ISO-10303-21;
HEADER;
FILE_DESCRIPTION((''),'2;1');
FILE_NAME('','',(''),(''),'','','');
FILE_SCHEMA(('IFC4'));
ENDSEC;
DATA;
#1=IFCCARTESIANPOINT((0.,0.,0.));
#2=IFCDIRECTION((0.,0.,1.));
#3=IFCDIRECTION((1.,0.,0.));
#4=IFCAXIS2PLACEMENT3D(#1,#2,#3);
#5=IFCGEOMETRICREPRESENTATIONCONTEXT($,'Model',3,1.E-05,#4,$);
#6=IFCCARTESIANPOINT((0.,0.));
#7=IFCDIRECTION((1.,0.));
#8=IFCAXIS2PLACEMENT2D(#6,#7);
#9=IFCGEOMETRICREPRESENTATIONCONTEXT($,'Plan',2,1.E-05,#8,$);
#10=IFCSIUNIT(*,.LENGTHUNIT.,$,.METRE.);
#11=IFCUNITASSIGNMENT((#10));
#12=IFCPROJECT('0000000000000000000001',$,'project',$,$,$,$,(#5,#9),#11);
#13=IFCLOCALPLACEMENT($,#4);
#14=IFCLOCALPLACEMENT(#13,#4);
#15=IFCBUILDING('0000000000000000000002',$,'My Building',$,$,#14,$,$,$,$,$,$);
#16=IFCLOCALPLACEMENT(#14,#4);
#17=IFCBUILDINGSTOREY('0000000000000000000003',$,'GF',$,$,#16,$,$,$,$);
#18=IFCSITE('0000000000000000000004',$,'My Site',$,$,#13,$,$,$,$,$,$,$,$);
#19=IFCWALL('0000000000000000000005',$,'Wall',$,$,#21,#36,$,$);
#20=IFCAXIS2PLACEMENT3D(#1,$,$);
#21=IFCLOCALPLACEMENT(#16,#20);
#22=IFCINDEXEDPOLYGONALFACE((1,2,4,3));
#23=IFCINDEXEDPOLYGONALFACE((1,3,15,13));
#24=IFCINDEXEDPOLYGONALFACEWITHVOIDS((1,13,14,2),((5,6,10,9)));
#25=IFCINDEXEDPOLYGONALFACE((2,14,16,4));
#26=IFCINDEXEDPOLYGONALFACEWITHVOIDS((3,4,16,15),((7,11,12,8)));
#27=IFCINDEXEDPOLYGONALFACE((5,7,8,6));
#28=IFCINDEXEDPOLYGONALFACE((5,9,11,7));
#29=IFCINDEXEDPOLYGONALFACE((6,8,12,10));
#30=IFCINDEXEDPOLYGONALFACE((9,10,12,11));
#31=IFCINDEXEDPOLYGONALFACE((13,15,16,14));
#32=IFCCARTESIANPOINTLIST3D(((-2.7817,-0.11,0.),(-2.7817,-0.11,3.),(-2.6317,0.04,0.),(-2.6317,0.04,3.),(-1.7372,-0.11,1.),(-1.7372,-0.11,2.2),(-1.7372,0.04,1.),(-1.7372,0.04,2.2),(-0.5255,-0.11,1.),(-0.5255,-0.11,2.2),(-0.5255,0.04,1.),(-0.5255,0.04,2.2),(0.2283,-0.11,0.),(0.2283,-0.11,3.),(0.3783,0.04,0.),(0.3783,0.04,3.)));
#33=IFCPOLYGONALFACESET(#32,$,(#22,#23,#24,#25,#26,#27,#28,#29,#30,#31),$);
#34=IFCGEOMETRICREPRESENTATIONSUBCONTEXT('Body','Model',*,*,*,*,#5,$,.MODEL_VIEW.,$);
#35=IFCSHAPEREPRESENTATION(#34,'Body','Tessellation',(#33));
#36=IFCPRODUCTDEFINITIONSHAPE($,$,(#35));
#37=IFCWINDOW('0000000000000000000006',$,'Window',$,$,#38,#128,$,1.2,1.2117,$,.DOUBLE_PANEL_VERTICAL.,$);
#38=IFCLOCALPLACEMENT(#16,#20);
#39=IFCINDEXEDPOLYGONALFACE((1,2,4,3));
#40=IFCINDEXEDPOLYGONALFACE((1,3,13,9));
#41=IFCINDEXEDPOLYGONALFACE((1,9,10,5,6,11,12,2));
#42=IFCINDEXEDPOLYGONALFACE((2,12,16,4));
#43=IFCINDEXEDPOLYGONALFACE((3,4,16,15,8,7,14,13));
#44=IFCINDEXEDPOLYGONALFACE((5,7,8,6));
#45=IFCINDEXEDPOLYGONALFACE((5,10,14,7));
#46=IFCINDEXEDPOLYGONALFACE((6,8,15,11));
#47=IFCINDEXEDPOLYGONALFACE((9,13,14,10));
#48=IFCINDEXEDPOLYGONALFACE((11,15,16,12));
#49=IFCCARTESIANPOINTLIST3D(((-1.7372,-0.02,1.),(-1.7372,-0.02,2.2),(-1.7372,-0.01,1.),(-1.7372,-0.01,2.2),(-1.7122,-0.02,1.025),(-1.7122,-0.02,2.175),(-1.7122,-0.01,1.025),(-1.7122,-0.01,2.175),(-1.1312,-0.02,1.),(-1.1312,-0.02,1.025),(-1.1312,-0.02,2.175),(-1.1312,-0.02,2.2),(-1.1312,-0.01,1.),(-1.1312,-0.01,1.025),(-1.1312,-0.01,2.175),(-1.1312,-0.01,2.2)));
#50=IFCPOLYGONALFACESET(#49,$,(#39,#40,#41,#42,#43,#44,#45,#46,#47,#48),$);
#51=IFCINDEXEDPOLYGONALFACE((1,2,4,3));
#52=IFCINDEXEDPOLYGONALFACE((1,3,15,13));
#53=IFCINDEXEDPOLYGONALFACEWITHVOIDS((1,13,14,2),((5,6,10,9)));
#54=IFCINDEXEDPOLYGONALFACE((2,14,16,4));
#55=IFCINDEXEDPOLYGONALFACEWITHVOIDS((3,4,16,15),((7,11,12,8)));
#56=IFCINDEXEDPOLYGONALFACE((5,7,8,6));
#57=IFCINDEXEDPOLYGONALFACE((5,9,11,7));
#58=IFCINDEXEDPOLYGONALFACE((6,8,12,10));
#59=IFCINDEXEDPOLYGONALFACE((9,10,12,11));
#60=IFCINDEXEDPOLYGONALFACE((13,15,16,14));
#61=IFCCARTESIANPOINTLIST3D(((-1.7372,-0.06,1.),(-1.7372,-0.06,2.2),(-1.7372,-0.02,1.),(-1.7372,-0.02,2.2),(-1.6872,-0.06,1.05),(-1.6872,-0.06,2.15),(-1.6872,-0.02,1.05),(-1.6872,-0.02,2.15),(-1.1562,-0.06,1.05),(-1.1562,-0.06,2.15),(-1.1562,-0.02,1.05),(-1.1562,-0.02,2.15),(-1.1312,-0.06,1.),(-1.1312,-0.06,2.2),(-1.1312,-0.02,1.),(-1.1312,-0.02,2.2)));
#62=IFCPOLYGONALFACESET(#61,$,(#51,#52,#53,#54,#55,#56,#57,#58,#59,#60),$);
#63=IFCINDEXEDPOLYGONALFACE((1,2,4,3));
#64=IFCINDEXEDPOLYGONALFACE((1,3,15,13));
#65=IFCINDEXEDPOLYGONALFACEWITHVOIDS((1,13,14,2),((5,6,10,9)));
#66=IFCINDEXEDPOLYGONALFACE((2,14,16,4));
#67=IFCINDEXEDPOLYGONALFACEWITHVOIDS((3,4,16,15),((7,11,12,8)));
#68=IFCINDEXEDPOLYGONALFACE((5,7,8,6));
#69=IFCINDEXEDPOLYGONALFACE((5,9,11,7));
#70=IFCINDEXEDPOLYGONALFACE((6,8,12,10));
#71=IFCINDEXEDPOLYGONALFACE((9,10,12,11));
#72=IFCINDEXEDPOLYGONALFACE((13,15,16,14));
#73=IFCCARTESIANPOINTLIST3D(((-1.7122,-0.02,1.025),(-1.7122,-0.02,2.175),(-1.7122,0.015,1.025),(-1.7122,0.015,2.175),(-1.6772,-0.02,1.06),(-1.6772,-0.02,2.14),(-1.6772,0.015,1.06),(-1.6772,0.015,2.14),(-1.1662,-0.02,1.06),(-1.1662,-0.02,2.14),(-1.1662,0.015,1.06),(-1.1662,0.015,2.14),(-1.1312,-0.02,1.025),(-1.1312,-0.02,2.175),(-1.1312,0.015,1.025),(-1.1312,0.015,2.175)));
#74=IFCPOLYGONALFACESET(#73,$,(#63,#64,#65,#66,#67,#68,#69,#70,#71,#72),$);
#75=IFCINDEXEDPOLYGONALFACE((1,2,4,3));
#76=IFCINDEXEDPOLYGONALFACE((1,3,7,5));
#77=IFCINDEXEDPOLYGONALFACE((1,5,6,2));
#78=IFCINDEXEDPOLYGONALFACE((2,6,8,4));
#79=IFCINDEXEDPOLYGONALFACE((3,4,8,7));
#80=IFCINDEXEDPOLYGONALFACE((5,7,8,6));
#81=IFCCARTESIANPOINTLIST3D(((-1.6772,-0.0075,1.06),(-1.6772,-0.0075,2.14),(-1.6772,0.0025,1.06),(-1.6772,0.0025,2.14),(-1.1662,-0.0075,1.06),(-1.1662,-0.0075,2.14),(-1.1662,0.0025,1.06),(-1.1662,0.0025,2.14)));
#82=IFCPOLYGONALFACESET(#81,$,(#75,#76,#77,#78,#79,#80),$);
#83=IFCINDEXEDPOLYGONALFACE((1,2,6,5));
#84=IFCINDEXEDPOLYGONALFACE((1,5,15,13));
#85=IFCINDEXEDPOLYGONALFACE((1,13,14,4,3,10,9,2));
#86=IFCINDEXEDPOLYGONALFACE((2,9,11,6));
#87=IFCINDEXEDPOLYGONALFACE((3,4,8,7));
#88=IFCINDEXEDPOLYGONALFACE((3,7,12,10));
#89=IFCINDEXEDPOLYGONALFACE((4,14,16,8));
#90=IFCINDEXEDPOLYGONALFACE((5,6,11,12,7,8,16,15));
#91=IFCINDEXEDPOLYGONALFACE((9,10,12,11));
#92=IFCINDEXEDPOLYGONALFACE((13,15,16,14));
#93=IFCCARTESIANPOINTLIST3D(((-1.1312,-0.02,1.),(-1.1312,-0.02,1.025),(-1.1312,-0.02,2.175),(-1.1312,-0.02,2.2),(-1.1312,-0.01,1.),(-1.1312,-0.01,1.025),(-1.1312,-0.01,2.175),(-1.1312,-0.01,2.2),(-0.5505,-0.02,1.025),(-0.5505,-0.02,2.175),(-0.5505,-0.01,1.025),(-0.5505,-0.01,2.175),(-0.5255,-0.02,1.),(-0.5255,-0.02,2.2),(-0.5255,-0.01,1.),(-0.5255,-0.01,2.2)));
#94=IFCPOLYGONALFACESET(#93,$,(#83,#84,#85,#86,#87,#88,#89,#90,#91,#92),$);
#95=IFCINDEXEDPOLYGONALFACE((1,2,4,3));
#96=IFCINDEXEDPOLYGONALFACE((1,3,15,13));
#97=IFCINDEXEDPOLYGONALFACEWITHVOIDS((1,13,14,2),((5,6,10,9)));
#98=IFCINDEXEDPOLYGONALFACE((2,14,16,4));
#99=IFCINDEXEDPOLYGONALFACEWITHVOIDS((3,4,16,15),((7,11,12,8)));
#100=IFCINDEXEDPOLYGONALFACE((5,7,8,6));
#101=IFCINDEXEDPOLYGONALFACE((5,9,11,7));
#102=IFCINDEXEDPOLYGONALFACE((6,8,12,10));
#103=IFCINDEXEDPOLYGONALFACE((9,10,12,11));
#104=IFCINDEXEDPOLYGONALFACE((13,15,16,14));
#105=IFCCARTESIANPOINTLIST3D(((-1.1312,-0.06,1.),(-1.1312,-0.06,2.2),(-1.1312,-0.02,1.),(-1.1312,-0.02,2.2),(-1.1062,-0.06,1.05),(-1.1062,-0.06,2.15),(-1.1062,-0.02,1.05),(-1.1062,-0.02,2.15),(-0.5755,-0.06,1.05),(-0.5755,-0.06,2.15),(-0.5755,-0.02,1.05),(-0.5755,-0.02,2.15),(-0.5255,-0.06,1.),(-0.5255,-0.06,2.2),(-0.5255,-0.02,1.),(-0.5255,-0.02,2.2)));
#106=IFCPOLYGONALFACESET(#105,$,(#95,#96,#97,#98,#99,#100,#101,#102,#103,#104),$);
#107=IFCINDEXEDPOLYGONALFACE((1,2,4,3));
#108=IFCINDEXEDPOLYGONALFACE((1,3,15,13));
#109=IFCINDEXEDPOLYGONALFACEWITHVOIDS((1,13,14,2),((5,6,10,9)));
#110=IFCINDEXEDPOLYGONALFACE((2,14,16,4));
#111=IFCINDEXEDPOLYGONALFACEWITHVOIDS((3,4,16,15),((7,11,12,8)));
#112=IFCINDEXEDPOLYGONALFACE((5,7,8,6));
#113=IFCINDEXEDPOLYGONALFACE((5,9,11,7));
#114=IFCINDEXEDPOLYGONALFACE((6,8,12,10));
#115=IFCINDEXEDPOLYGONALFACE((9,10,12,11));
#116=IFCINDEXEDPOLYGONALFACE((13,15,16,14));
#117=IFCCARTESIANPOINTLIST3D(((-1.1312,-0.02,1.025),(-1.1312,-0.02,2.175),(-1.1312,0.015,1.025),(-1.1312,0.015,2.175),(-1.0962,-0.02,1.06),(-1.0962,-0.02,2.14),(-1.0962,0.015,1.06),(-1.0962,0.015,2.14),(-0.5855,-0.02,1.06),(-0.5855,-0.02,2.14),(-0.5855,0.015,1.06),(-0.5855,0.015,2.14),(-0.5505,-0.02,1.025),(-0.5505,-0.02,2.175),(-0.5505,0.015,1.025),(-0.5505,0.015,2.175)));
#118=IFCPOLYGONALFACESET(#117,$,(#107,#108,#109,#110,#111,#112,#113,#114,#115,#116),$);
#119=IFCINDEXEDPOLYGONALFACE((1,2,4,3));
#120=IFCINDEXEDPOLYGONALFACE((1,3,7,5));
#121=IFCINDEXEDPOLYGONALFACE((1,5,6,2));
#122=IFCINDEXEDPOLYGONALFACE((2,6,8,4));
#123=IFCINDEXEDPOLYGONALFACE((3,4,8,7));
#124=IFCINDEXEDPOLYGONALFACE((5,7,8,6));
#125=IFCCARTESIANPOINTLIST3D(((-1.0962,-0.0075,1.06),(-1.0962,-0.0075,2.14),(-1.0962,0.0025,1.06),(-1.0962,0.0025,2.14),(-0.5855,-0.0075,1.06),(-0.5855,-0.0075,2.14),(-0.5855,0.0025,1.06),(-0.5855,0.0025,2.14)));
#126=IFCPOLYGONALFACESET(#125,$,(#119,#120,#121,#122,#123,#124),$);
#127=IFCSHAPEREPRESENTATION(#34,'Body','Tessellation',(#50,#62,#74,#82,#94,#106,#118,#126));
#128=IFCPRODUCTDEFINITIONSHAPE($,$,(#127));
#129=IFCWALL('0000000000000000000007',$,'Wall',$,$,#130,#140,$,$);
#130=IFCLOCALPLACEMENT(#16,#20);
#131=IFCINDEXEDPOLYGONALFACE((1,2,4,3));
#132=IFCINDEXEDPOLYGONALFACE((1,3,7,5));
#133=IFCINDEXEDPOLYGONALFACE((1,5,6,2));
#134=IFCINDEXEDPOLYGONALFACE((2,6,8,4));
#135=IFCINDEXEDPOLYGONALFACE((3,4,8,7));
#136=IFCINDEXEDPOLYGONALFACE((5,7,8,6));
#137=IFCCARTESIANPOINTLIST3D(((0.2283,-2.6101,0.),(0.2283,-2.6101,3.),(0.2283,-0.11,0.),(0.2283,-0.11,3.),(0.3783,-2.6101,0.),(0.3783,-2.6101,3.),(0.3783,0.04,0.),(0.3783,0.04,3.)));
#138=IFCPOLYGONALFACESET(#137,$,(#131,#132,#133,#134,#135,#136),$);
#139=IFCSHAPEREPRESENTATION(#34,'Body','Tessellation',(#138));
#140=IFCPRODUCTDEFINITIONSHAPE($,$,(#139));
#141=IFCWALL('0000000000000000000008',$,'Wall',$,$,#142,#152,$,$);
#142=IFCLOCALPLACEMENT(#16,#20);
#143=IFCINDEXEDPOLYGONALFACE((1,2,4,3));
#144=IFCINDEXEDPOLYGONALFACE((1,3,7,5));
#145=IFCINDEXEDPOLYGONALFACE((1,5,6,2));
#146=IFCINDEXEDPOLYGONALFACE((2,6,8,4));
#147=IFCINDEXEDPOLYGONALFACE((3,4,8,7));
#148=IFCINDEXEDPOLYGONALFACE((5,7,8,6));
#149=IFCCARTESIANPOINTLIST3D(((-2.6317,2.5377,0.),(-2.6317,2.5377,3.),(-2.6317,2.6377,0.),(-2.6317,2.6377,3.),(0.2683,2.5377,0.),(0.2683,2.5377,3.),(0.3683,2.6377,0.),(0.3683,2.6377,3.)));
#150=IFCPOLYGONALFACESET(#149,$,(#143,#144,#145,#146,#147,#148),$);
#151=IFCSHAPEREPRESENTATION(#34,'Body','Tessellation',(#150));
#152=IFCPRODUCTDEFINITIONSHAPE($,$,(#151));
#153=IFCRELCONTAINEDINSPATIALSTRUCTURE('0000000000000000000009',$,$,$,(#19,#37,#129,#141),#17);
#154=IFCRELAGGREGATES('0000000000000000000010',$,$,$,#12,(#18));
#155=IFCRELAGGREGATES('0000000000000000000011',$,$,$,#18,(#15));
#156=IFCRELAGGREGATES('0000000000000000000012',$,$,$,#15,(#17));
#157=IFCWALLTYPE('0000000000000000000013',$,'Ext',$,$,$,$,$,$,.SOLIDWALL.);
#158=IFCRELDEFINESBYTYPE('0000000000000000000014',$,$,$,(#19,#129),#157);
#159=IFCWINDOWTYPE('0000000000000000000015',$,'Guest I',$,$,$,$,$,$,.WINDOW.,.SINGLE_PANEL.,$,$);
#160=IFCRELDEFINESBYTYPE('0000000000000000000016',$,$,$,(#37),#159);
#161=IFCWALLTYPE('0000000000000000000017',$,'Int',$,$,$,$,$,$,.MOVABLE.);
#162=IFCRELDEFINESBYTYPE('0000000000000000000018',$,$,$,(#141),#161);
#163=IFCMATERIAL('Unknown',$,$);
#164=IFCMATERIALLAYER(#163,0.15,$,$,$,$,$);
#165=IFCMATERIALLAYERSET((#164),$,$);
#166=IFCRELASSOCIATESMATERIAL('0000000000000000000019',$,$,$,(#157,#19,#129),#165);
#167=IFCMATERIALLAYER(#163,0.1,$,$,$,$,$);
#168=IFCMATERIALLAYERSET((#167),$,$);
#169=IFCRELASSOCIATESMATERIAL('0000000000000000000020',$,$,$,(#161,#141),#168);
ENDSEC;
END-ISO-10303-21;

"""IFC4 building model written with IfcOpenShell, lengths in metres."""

from ifc_helpers import new_model, entity, si_unit, frame, origin_with_axes, origin_2d_with_axis, place, context, subcontext, project, spatial, line, indexed_curve, outline, extrude, shape, source, transform, mapped, material, layer, layer_set, layer_usage, type_object, type_shapes, element, fill, save


model = new_model("IFC4")

# Units and contexts
model_context = context("Model", 3, precision=1e-05, world=origin_with_axes())
plan_context = context("Plan", 2, precision=1e-05, world=origin_2d_with_axis())
body_context_1 = subcontext(model_context, "Body", "Model", "MODEL_VIEW")
body_context_2 = subcontext(plan_context, "Body", "Plan", "PLAN_VIEW")
ifc_project = project(units=[si_unit("LENGTHUNIT", "METRE")], contexts=[model_context, plan_context])

# Site, building, storey
site_placement = place(None, origin_with_axes())
site = spatial("IfcSite", under=ifc_project, at=site_placement, Name="My Site")
building_placement = place(site_placement, origin_with_axes())
building = spatial("IfcBuilding", under=site, at=building_placement, Name="My Building")
storey_placement = place(building_placement, origin_with_axes())
storey = spatial("IfcBuildingStorey", under=building, at=storey_placement, Name="GF")

# Shared definitions
ifc_material = material(Name="Unknown")

# Shared definitions
ifc_layer_1 = layer(ifc_material, 0.15)
ifc_layer_set_1 = layer_set([ifc_layer_1])
wall_type_1 = type_object("IfcWallType", Name="Ext", PredefinedType="SOLIDWALL", material=ifc_layer_set_1)

# Wall, opening, window
ifc_layer_usage_1 = layer_usage(ifc_layer_set_1, "AXIS2", "POSITIVE", 0.0)
wall_1_placement = place(storey_placement, frame((-2.7817, -0.11, 0.0), z_axis=(0.0, 0.0, 1.0), x_axis=(1.0, 0.0, 0.0)))
wall_1 = element("IfcWall", 1, at=wall_1_placement, inside=storey, type_object=wall_type_1, material=ifc_layer_usage_1, Name="Wall", context=body_context_1, shape_type="SweptSolid", body=[
    extrude(outline(indexed_curve([(0.0, 0.0), (0.15, 0.15), (3.16, 0.15), (3.01, 0.0)], segments=[line(1, 2, 3, 4, 1)])), origin_with_axes(), (0.0, 0.0, 1.0), 3.0),
])
shared_shape_1 = source(origin_with_axes(), body_context_1, "Body", "SweptSolid", [
    extrude(outline(indexed_curve([(0.0, 0.0), (1.2117, 0.0), (1.2117, 1.2), (0.0, 1.2)], segments=[line(1, 2, 3, 4, 1)])), frame((0.0, -0.6, 0.0), z_axis=(0.0, -1.0, 0.0), x_axis=(1.0, 0.0, 0.0)), (0.0, 0.0, -1.0), 1.2),
])
opening_1_placement = place(wall_1_placement, frame((1.0445, 0.0, 1.0), z_axis=(0.0, 0.0, 1.0), x_axis=(1.0, 0.0, 0.0)))
opening_1 = element("IfcOpeningElement", 2, at=opening_1_placement, cuts=wall_1, PredefinedType="OPENING", context=body_context_1, shape_type="MappedRepresentation", body=[
    mapped(shared_shape_1, transform((0.0, 0.0, 0.0), x_axis=(1.0, 0.0, 0.0), y_axis=(0.0, 1.0, 0.0), z_axis=(0.0, 0.0, 1.0), scale=1.0)),
])
window_type_1 = type_object("IfcWindowType", Name="Guest I", PartitioningType="SINGLE_PANEL", PredefinedType="WINDOW")
shared_shape_2 = source(origin_with_axes(), body_context_1, "Body", "SweptSolid", [
    extrude(outline(indexed_curve([(0.606, 0.0), (0.0, 0.0), (0.0, 1.2), (0.606, 1.2), (0.606, 1.175), (0.025, 1.175), (0.025, 0.025), (0.606, 0.025)], segments=[line(1, 2, 3, 4, 5, 6, 7, 8, 1)])), frame((0.0, 0.09, 0.0), z_axis=(0.0, -1.0, 0.0), x_axis=(1.0, 0.0, 0.0)), (0.0, 0.0, -1.0), 0.01),
    extrude(outline(indexed_curve([(0.0, 0.0), (0.606, 0.0), (0.606, 1.2), (0.0, 1.2)], segments=[line(1, 2, 3, 4, 1)]), holes=[indexed_curve([(0.05, 0.05), (0.581, 0.05), (0.581, 1.15), (0.05, 1.15)], segments=[line(1, 2, 3, 4, 1)])]), frame((0.0, 0.05, 0.0), z_axis=(0.0, -1.0, 0.0), x_axis=(1.0, 0.0, 0.0)), (0.0, 0.0, -1.0), 0.04),
    extrude(outline(indexed_curve([(0.0, 0.0), (0.581, 0.0), (0.581, 1.15), (0.0, 1.15)], segments=[line(1, 2, 3, 4, 1)]), holes=[indexed_curve([(0.035, 0.035), (0.546, 0.035), (0.546, 1.115), (0.035, 1.115)], segments=[line(1, 2, 3, 4, 1)])]), frame((0.025, 0.09, 0.025), z_axis=(0.0, -1.0, 0.0), x_axis=(1.0, 0.0, 0.0)), (0.0, 0.0, -1.0), 0.035),
    extrude(outline(indexed_curve([(0.035, 0.035), (0.546, 0.035), (0.546, 1.115), (0.035, 1.115)], segments=[line(1, 2, 3, 4, 1)])), frame((0.025, 0.1025, 0.025), z_axis=(0.0, -1.0, 0.0), x_axis=(1.0, 0.0, 0.0)), (0.0, 0.0, -1.0), 0.01),
    extrude(outline(indexed_curve([(0.0, 1.2), (0.6057, 1.2), (0.6057, 0.0), (0.0, 0.0), (0.0, 0.025), (0.5807, 0.025), (0.5807, 1.175), (0.0, 1.175)], segments=[line(1, 2, 3, 4, 5, 6, 7, 8, 1)])), frame((0.606, 0.09, 0.0), z_axis=(0.0, -1.0, 0.0), x_axis=(1.0, 0.0, 0.0)), (0.0, 0.0, -1.0), 0.01),
    extrude(outline(indexed_curve([(0.0, 0.0), (0.6057, 0.0), (0.6057, 1.2), (0.0, 1.2)], segments=[line(1, 2, 3, 4, 1)]), holes=[indexed_curve([(0.025, 0.05), (0.5557, 0.05), (0.5557, 1.15), (0.025, 1.15)], segments=[line(1, 2, 3, 4, 1)])]), frame((0.606, 0.05, 0.0), z_axis=(0.0, -1.0, 0.0), x_axis=(1.0, 0.0, 0.0)), (0.0, 0.0, -1.0), 0.04),
    extrude(outline(indexed_curve([(0.0, 0.0), (0.5807, 0.0), (0.5807, 1.15), (0.0, 1.15)], segments=[line(1, 2, 3, 4, 1)]), holes=[indexed_curve([(0.035, 0.035), (0.5457, 0.035), (0.5457, 1.115), (0.035, 1.115)], segments=[line(1, 2, 3, 4, 1)])]), frame((0.606, 0.09, 0.025), z_axis=(0.0, -1.0, 0.0), x_axis=(1.0, 0.0, 0.0)), (0.0, 0.0, -1.0), 0.035),
    extrude(outline(indexed_curve([(0.035, 0.035), (0.5457, 0.035), (0.5457, 1.115), (0.035, 1.115)], segments=[line(1, 2, 3, 4, 1)])), frame((0.606, 0.1025, 0.025), z_axis=(0.0, -1.0, 0.0), x_axis=(1.0, 0.0, 0.0)), (0.0, 0.0, -1.0), 0.01),
])
shared_shape_3 = source(origin_with_axes(), body_context_2, "Body", "Curve2D", [
    entity("IfcIndexedPolyCurve", entity("IfcCartesianPointList2D", [[0.05, 0.05], [0.581, 0.05]])),
    entity("IfcIndexedPolyCurve", entity("IfcCartesianPointList2D", [[0.0, 0.1], [0.025, 0.1], [0.025, 0.09], [0.05, 0.09], [0.05, 0.05], [0.0, 0.05]]), [entity("IfcLineIndex", [1, 2, 3, 4, 5, 6, 1])]),
    entity("IfcIndexedPolyCurve", entity("IfcCartesianPointList2D", [[0.606, 0.1], [0.606, 0.1], [0.606, 0.09], [0.581, 0.09], [0.581, 0.05], [0.606, 0.05]])),
    entity("IfcIndexedPolyCurve", entity("IfcCartesianPointList2D", [[0.025, 0.09], [0.06, 0.09], [0.06, 0.125], [0.025, 0.125]]), [entity("IfcLineIndex", [1, 2, 3, 4, 1])]),
    entity("IfcIndexedPolyCurve", entity("IfcCartesianPointList2D", [[0.606, 0.09], [0.571, 0.09], [0.571, 0.125], [0.606, 0.125]]), [entity("IfcLineIndex", [1, 2, 3, 4, 1])]),
    entity("IfcIndexedPolyCurve", entity("IfcCartesianPointList2D", [[0.06, 0.09], [0.571, 0.09]])),
    entity("IfcIndexedPolyCurve", entity("IfcCartesianPointList2D", [[0.06, 0.125], [0.571, 0.125]])),
    entity("IfcIndexedPolyCurve", entity("IfcCartesianPointList2D", [[0.06, 0.1075], [0.571, 0.1075]])),
    entity("IfcIndexedPolyCurve", entity("IfcCartesianPointList2D", [[0.631, 0.05], [1.1617, 0.05]])),
    entity("IfcIndexedPolyCurve", entity("IfcCartesianPointList2D", [[0.606, 0.1], [0.606, 0.1], [0.606, 0.09], [0.631, 0.09], [0.631, 0.05], [0.606, 0.05]])),
    entity("IfcIndexedPolyCurve", entity("IfcCartesianPointList2D", [[1.2117, 0.1], [1.1867, 0.1], [1.1867, 0.09], [1.1617, 0.09], [1.1617, 0.05], [1.2117, 0.05]]), [entity("IfcLineIndex", [1, 2, 3, 4, 5, 6, 1])]),
    entity("IfcIndexedPolyCurve", entity("IfcCartesianPointList2D", [[0.606, 0.09], [0.641, 0.09], [0.641, 0.125], [0.606, 0.125]]), [entity("IfcLineIndex", [1, 2, 3, 4, 1])]),
    entity("IfcIndexedPolyCurve", entity("IfcCartesianPointList2D", [[1.1867, 0.09], [1.1517, 0.09], [1.1517, 0.125], [1.1867, 0.125]]), [entity("IfcLineIndex", [1, 2, 3, 4, 1])]),
    entity("IfcIndexedPolyCurve", entity("IfcCartesianPointList2D", [[0.641, 0.09], [1.1517, 0.09]])),
    entity("IfcIndexedPolyCurve", entity("IfcCartesianPointList2D", [[0.641, 0.125], [1.1517, 0.125]])),
    entity("IfcIndexedPolyCurve", entity("IfcCartesianPointList2D", [[0.641, 0.1075], [1.1517, 0.1075]])),
])
type_shapes(window_type_1, [shared_shape_2, shared_shape_3])
window_1_placement = place(opening_1_placement, origin_with_axes())
window_1 = element("IfcWindow", 3, at=window_1_placement, inside=storey, type_object=window_type_1, Name="Window", OverallHeight=1.2, OverallWidth=1.2117, PartitioningType="DOUBLE_PANEL_VERTICAL", shapes=[
    shape(body_context_1, "Body", "MappedRepresentation", [mapped(shared_shape_2, transform((0.0, 0.0, 0.0), x_axis=(1.0, 0.0, 0.0), y_axis=(0.0, 1.0, 0.0), z_axis=(0.0, 0.0, 1.0), scale=1.0))]),
    shape(body_context_2, "Body", "MappedRepresentation", [mapped(shared_shape_3, transform((0.0, 0.0, 0.0), x_axis=(1.0, 0.0, 0.0), y_axis=(0.0, 1.0, 0.0), z_axis=(0.0, 0.0, 1.0), scale=1.0))]),
])
fill(opening_1, window_1)

# Walls
ifc_layer_usage_2 = layer_usage(ifc_layer_set_1, "AXIS2", "POSITIVE", 0.0)
wall_2_placement = place(storey_placement, frame((0.2283, -0.11, 0.0), z_axis=(0.0, 0.0, 1.0), x_axis=(0.0, -1.0, 0.0)))
element("IfcWall", 4, at=wall_2_placement, inside=storey, type_object=wall_type_1, material=ifc_layer_usage_2, Name="Wall", context=body_context_1, shape_type="SweptSolid", body=[
    extrude(outline(indexed_curve([(0.0, 0.0), (-0.15, 0.15), (2.5001, 0.15), (2.5001, 0.0)], segments=[line(1, 2, 3, 4, 1)])), origin_with_axes(), (0.0, 0.0, 1.0), 3.0),
])
ifc_layer_2 = layer(ifc_material, 0.1)
ifc_layer_set_2 = layer_set([ifc_layer_2])
ifc_layer_usage_3 = layer_usage(ifc_layer_set_2, "AXIS2", "POSITIVE", 0.0)
wall_type_2 = type_object("IfcWallType", Name="Int", PredefinedType="MOVABLE", material=ifc_layer_set_2)
wall_3_placement = place(storey_placement, frame((-2.6317, 2.5377, 0.0), z_axis=(0.0, 0.0, 1.0), x_axis=(1.0, 0.0, 0.0)))
element("IfcWall", 5, at=wall_3_placement, inside=storey, type_object=wall_type_2, material=ifc_layer_usage_3, Name="Wall", context=body_context_1, shape_type="SweptSolid", body=[
    extrude(outline(indexed_curve([(0.0, 0.0), (0.0, 0.1), (3.0, 0.1), (2.9, 0.0)], segments=[line(1, 2, 3, 4, 1)])), origin_with_axes(), (0.0, 0.0, 1.0), 3.0),
])

save(model, "model.ifc")
